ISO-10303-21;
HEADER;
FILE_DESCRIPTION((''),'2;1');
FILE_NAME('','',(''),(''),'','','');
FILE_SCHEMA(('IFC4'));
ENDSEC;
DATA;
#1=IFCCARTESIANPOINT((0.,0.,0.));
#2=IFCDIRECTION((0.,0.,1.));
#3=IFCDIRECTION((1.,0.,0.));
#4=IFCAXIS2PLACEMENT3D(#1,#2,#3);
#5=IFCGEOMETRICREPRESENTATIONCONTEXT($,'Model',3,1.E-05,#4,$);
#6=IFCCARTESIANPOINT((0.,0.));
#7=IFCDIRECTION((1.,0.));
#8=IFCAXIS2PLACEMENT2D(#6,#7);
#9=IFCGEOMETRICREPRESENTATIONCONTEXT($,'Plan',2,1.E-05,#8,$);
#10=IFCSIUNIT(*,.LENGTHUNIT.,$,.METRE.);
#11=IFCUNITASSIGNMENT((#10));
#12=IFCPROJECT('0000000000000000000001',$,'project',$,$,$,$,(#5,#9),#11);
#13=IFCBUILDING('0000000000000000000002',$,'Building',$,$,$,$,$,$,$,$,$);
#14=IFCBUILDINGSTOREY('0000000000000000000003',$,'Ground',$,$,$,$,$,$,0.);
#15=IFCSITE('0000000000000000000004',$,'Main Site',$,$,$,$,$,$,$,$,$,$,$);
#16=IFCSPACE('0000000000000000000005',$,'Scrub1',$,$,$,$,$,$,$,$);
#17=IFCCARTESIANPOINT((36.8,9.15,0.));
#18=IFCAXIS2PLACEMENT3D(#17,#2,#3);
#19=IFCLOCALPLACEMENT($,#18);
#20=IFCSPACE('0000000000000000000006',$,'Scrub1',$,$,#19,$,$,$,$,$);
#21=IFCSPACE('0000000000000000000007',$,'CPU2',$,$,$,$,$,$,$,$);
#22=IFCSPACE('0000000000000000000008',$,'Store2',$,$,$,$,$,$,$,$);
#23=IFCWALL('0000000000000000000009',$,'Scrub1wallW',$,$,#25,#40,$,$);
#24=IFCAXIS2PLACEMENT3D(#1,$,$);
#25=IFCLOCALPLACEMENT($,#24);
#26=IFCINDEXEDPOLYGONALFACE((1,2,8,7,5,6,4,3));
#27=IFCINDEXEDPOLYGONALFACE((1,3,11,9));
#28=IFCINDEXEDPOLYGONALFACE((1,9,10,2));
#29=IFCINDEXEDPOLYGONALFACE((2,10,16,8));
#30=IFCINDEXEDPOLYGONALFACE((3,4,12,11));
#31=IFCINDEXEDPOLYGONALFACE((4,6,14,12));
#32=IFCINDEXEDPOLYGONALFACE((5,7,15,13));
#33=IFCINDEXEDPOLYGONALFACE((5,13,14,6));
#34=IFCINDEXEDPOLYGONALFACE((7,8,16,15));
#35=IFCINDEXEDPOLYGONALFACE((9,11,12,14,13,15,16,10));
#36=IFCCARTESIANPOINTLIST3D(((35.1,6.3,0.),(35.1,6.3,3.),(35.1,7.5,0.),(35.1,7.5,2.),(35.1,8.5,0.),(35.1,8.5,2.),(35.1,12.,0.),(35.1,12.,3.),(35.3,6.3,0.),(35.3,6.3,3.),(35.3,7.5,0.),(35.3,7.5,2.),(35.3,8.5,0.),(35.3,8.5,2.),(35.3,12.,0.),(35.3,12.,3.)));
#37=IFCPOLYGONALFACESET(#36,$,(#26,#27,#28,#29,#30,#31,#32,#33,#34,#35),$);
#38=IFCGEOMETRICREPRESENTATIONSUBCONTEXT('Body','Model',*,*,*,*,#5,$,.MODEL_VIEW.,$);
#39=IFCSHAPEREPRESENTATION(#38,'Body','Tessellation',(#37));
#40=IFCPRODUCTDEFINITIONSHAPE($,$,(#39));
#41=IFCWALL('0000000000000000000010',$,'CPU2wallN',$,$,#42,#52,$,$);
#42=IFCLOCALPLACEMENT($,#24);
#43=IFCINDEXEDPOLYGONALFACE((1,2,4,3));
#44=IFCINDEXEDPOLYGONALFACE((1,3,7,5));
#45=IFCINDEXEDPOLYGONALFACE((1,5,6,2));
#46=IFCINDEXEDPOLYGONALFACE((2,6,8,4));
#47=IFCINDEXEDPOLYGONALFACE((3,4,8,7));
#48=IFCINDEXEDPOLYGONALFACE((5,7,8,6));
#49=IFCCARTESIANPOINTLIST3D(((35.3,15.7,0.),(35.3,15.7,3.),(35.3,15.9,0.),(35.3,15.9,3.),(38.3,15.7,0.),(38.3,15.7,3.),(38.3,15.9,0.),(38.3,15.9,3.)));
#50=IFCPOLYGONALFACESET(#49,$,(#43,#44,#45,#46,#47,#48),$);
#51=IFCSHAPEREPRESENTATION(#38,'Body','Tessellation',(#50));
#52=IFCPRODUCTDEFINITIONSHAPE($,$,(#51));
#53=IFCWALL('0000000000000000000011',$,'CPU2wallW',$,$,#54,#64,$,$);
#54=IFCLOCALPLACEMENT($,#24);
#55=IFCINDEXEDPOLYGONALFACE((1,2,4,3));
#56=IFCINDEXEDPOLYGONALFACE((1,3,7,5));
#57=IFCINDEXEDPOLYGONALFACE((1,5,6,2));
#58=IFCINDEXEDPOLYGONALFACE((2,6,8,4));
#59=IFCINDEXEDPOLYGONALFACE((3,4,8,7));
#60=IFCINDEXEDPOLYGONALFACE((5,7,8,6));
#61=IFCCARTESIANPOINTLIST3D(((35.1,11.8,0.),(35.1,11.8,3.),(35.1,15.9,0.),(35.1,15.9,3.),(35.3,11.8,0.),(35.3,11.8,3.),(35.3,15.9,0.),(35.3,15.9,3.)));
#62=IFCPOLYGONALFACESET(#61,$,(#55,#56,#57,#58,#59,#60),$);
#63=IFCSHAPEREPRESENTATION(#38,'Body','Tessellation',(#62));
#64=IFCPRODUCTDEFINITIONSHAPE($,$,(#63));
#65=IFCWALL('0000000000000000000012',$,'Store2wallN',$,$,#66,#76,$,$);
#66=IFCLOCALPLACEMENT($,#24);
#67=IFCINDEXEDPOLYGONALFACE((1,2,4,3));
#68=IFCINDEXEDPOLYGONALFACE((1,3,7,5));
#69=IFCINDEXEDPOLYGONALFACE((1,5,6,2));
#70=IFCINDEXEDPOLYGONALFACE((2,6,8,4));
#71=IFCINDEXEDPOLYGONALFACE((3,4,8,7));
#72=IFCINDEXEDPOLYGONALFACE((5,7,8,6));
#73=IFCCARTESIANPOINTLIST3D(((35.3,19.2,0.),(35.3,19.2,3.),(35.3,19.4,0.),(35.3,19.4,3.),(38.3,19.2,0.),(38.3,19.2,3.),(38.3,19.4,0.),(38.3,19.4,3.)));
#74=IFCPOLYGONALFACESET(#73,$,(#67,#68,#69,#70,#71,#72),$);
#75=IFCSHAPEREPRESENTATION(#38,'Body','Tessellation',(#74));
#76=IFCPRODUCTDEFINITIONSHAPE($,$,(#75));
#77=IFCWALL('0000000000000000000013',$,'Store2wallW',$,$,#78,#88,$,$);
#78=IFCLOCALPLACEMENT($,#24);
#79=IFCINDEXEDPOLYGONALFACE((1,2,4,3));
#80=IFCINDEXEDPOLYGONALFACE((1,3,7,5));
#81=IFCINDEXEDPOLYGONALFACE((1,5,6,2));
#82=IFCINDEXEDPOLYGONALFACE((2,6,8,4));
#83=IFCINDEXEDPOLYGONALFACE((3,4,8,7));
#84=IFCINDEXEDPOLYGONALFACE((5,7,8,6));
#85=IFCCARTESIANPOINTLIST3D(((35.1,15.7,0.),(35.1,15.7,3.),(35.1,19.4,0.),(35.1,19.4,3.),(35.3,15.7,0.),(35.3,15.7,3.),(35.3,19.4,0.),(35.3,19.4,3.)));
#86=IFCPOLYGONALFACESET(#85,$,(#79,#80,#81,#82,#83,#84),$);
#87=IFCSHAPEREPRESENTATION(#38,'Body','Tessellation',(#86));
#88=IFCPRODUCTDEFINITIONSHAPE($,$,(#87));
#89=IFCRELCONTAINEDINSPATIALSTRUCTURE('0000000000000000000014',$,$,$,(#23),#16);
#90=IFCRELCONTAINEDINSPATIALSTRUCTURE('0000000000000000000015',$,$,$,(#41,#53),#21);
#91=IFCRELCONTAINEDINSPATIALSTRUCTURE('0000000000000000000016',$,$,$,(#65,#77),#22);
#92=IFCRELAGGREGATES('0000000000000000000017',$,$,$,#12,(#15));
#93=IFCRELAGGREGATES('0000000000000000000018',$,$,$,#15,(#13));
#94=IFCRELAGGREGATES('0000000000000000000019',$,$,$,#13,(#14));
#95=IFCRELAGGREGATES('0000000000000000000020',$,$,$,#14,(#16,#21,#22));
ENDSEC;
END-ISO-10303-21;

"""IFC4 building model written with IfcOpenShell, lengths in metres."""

from ifc_helpers import new_model, si_unit, frame, origin_with_axes, origin_2d_with_axis, place, context, subcontext, project, spatial, indexed_curve, outline, extrude, element, save


model = new_model("IFC4")

# Units and contexts
model_context = context("Model", 3, precision=1e-05, world=origin_with_axes())
plan_context = context("Plan", 2, precision=1e-05, world=origin_2d_with_axis())
body_context = subcontext(model_context, "Body", "Model", "MODEL_VIEW")
ifc_project = project(units=[si_unit("LENGTHUNIT", "METRE")], contexts=[model_context, plan_context])

# Site, building, storey
site = spatial("IfcSite", under=ifc_project, Name="Main Site")
building = spatial("IfcBuilding", under=site, Name="Building")
storey = spatial("IfcBuildingStorey", under=building, Name="Ground", Elevation=0.0)

# Shared definitions
space_1 = spatial("IfcSpace", under=storey, Name="Scrub1")

# Shared definitions
space_2_placement = place(None, frame((36.8, 9.15, 0.0), z_axis=(0.0, 0.0, 1.0), x_axis=(1.0, 0.0, 0.0)))
space_2 = spatial("IfcSpace", at=space_2_placement, Name="Scrub1")

# Wall, opening
wall_1_placement = place(None, frame((35.3, 6.3, 0.0), z_axis=(0.0, 0.0, 1.0), x_axis=(0.0, 1.0, 0.0)))
wall_1 = element("IfcWall", 1, at=wall_1_placement, inside=space_1, Name="Scrub1wallW", context=body_context, shape_type="SweptSolid", body=[
    extrude(outline(indexed_curve([(0.0, 0.0), (0.0, 0.2), (5.7, 0.2), (5.7, 0.0), (0.0, 0.0)], self_intersect=False)), origin_with_axes(), (0.0, 0.0, 1.0), 3.0),
])
opening_1_placement = place(wall_1_placement, frame((1.2, 0.0, 0.0), z_axis=(0.0, 0.0, 1.0), x_axis=(1.0, 0.0, 0.0)))
element("IfcOpeningElement", 2, at=opening_1_placement, inside=space_2, cuts=wall_1, context=body_context, shape_type="SweptSolid", body=[
    extrude(outline(indexed_curve([(0.0, 0.0), (0.0, 0.4), (1.0, 0.4), (1.0, 0.0), (0.0, 0.0)], self_intersect=False)), origin_with_axes(), (0.0, 0.0, 1.0), 2.0),
])

# Shared definitions
space_3 = spatial("IfcSpace", under=storey, Name="CPU2")

# Walls
for number, where, z_axis, x_axis, name in (
    (3, (35.3, 15.7, 0.0), (0.0, 0.0, 1.0), (1.0, 0.0, 0.0), "CPU2wallN"),
):
    element("IfcWall", number, at=place(None, frame(where, z_axis=z_axis, x_axis=x_axis)), inside=space_3, Name=name, context=body_context, shape_type="SweptSolid", body=[
        extrude(outline(indexed_curve([(0.0, 0.0), (0.0, 0.2), (3.0, 0.2), (3.0, 0.0), (0.0, 0.0)], self_intersect=False)), origin_with_axes(), (0.0, 0.0, 1.0), 3.0),
    ])
wall_2_placement = place(None, frame((35.3, 11.8, 0.0), z_axis=(0.0, 0.0, 1.0), x_axis=(0.0, 1.0, 0.0)))
element("IfcWall", 4, at=wall_2_placement, inside=space_3, Name="CPU2wallW", context=body_context, shape_type="SweptSolid", body=[
    extrude(outline(indexed_curve([(0.0, 0.0), (0.0, 0.2), (4.1, 0.2), (4.1, 0.0), (0.0, 0.0)], self_intersect=False)), origin_with_axes(), (0.0, 0.0, 1.0), 3.0),
])

# Shared definitions
space_4 = spatial("IfcSpace", under=storey, Name="Store2")

# Walls
for number, where, z_axis, x_axis, name in (
    (5, (35.3, 19.2, 0.0), (0.0, 0.0, 1.0), (1.0, 0.0, 0.0), "Store2wallN"),
):
    element("IfcWall", number, at=place(None, frame(where, z_axis=z_axis, x_axis=x_axis)), inside=space_4, Name=name, context=body_context, shape_type="SweptSolid", body=[
        extrude(outline(indexed_curve([(0.0, 0.0), (0.0, 0.2), (3.0, 0.2), (3.0, 0.0), (0.0, 0.0)], self_intersect=False)), origin_with_axes(), (0.0, 0.0, 1.0), 3.0),
    ])
wall_3_placement = place(None, frame((35.3, 15.7, 0.0), z_axis=(0.0, 0.0, 1.0), x_axis=(0.0, 1.0, 0.0)))
element("IfcWall", 6, at=wall_3_placement, inside=space_4, Name="Store2wallW", context=body_context, shape_type="SweptSolid", body=[
    extrude(outline(indexed_curve([(0.0, 0.0), (0.0, 0.2), (3.7, 0.2), (3.7, 0.0), (0.0, 0.0)], self_intersect=False)), origin_with_axes(), (0.0, 0.0, 1.0), 3.0),
])

save(model, "model.ifc")
